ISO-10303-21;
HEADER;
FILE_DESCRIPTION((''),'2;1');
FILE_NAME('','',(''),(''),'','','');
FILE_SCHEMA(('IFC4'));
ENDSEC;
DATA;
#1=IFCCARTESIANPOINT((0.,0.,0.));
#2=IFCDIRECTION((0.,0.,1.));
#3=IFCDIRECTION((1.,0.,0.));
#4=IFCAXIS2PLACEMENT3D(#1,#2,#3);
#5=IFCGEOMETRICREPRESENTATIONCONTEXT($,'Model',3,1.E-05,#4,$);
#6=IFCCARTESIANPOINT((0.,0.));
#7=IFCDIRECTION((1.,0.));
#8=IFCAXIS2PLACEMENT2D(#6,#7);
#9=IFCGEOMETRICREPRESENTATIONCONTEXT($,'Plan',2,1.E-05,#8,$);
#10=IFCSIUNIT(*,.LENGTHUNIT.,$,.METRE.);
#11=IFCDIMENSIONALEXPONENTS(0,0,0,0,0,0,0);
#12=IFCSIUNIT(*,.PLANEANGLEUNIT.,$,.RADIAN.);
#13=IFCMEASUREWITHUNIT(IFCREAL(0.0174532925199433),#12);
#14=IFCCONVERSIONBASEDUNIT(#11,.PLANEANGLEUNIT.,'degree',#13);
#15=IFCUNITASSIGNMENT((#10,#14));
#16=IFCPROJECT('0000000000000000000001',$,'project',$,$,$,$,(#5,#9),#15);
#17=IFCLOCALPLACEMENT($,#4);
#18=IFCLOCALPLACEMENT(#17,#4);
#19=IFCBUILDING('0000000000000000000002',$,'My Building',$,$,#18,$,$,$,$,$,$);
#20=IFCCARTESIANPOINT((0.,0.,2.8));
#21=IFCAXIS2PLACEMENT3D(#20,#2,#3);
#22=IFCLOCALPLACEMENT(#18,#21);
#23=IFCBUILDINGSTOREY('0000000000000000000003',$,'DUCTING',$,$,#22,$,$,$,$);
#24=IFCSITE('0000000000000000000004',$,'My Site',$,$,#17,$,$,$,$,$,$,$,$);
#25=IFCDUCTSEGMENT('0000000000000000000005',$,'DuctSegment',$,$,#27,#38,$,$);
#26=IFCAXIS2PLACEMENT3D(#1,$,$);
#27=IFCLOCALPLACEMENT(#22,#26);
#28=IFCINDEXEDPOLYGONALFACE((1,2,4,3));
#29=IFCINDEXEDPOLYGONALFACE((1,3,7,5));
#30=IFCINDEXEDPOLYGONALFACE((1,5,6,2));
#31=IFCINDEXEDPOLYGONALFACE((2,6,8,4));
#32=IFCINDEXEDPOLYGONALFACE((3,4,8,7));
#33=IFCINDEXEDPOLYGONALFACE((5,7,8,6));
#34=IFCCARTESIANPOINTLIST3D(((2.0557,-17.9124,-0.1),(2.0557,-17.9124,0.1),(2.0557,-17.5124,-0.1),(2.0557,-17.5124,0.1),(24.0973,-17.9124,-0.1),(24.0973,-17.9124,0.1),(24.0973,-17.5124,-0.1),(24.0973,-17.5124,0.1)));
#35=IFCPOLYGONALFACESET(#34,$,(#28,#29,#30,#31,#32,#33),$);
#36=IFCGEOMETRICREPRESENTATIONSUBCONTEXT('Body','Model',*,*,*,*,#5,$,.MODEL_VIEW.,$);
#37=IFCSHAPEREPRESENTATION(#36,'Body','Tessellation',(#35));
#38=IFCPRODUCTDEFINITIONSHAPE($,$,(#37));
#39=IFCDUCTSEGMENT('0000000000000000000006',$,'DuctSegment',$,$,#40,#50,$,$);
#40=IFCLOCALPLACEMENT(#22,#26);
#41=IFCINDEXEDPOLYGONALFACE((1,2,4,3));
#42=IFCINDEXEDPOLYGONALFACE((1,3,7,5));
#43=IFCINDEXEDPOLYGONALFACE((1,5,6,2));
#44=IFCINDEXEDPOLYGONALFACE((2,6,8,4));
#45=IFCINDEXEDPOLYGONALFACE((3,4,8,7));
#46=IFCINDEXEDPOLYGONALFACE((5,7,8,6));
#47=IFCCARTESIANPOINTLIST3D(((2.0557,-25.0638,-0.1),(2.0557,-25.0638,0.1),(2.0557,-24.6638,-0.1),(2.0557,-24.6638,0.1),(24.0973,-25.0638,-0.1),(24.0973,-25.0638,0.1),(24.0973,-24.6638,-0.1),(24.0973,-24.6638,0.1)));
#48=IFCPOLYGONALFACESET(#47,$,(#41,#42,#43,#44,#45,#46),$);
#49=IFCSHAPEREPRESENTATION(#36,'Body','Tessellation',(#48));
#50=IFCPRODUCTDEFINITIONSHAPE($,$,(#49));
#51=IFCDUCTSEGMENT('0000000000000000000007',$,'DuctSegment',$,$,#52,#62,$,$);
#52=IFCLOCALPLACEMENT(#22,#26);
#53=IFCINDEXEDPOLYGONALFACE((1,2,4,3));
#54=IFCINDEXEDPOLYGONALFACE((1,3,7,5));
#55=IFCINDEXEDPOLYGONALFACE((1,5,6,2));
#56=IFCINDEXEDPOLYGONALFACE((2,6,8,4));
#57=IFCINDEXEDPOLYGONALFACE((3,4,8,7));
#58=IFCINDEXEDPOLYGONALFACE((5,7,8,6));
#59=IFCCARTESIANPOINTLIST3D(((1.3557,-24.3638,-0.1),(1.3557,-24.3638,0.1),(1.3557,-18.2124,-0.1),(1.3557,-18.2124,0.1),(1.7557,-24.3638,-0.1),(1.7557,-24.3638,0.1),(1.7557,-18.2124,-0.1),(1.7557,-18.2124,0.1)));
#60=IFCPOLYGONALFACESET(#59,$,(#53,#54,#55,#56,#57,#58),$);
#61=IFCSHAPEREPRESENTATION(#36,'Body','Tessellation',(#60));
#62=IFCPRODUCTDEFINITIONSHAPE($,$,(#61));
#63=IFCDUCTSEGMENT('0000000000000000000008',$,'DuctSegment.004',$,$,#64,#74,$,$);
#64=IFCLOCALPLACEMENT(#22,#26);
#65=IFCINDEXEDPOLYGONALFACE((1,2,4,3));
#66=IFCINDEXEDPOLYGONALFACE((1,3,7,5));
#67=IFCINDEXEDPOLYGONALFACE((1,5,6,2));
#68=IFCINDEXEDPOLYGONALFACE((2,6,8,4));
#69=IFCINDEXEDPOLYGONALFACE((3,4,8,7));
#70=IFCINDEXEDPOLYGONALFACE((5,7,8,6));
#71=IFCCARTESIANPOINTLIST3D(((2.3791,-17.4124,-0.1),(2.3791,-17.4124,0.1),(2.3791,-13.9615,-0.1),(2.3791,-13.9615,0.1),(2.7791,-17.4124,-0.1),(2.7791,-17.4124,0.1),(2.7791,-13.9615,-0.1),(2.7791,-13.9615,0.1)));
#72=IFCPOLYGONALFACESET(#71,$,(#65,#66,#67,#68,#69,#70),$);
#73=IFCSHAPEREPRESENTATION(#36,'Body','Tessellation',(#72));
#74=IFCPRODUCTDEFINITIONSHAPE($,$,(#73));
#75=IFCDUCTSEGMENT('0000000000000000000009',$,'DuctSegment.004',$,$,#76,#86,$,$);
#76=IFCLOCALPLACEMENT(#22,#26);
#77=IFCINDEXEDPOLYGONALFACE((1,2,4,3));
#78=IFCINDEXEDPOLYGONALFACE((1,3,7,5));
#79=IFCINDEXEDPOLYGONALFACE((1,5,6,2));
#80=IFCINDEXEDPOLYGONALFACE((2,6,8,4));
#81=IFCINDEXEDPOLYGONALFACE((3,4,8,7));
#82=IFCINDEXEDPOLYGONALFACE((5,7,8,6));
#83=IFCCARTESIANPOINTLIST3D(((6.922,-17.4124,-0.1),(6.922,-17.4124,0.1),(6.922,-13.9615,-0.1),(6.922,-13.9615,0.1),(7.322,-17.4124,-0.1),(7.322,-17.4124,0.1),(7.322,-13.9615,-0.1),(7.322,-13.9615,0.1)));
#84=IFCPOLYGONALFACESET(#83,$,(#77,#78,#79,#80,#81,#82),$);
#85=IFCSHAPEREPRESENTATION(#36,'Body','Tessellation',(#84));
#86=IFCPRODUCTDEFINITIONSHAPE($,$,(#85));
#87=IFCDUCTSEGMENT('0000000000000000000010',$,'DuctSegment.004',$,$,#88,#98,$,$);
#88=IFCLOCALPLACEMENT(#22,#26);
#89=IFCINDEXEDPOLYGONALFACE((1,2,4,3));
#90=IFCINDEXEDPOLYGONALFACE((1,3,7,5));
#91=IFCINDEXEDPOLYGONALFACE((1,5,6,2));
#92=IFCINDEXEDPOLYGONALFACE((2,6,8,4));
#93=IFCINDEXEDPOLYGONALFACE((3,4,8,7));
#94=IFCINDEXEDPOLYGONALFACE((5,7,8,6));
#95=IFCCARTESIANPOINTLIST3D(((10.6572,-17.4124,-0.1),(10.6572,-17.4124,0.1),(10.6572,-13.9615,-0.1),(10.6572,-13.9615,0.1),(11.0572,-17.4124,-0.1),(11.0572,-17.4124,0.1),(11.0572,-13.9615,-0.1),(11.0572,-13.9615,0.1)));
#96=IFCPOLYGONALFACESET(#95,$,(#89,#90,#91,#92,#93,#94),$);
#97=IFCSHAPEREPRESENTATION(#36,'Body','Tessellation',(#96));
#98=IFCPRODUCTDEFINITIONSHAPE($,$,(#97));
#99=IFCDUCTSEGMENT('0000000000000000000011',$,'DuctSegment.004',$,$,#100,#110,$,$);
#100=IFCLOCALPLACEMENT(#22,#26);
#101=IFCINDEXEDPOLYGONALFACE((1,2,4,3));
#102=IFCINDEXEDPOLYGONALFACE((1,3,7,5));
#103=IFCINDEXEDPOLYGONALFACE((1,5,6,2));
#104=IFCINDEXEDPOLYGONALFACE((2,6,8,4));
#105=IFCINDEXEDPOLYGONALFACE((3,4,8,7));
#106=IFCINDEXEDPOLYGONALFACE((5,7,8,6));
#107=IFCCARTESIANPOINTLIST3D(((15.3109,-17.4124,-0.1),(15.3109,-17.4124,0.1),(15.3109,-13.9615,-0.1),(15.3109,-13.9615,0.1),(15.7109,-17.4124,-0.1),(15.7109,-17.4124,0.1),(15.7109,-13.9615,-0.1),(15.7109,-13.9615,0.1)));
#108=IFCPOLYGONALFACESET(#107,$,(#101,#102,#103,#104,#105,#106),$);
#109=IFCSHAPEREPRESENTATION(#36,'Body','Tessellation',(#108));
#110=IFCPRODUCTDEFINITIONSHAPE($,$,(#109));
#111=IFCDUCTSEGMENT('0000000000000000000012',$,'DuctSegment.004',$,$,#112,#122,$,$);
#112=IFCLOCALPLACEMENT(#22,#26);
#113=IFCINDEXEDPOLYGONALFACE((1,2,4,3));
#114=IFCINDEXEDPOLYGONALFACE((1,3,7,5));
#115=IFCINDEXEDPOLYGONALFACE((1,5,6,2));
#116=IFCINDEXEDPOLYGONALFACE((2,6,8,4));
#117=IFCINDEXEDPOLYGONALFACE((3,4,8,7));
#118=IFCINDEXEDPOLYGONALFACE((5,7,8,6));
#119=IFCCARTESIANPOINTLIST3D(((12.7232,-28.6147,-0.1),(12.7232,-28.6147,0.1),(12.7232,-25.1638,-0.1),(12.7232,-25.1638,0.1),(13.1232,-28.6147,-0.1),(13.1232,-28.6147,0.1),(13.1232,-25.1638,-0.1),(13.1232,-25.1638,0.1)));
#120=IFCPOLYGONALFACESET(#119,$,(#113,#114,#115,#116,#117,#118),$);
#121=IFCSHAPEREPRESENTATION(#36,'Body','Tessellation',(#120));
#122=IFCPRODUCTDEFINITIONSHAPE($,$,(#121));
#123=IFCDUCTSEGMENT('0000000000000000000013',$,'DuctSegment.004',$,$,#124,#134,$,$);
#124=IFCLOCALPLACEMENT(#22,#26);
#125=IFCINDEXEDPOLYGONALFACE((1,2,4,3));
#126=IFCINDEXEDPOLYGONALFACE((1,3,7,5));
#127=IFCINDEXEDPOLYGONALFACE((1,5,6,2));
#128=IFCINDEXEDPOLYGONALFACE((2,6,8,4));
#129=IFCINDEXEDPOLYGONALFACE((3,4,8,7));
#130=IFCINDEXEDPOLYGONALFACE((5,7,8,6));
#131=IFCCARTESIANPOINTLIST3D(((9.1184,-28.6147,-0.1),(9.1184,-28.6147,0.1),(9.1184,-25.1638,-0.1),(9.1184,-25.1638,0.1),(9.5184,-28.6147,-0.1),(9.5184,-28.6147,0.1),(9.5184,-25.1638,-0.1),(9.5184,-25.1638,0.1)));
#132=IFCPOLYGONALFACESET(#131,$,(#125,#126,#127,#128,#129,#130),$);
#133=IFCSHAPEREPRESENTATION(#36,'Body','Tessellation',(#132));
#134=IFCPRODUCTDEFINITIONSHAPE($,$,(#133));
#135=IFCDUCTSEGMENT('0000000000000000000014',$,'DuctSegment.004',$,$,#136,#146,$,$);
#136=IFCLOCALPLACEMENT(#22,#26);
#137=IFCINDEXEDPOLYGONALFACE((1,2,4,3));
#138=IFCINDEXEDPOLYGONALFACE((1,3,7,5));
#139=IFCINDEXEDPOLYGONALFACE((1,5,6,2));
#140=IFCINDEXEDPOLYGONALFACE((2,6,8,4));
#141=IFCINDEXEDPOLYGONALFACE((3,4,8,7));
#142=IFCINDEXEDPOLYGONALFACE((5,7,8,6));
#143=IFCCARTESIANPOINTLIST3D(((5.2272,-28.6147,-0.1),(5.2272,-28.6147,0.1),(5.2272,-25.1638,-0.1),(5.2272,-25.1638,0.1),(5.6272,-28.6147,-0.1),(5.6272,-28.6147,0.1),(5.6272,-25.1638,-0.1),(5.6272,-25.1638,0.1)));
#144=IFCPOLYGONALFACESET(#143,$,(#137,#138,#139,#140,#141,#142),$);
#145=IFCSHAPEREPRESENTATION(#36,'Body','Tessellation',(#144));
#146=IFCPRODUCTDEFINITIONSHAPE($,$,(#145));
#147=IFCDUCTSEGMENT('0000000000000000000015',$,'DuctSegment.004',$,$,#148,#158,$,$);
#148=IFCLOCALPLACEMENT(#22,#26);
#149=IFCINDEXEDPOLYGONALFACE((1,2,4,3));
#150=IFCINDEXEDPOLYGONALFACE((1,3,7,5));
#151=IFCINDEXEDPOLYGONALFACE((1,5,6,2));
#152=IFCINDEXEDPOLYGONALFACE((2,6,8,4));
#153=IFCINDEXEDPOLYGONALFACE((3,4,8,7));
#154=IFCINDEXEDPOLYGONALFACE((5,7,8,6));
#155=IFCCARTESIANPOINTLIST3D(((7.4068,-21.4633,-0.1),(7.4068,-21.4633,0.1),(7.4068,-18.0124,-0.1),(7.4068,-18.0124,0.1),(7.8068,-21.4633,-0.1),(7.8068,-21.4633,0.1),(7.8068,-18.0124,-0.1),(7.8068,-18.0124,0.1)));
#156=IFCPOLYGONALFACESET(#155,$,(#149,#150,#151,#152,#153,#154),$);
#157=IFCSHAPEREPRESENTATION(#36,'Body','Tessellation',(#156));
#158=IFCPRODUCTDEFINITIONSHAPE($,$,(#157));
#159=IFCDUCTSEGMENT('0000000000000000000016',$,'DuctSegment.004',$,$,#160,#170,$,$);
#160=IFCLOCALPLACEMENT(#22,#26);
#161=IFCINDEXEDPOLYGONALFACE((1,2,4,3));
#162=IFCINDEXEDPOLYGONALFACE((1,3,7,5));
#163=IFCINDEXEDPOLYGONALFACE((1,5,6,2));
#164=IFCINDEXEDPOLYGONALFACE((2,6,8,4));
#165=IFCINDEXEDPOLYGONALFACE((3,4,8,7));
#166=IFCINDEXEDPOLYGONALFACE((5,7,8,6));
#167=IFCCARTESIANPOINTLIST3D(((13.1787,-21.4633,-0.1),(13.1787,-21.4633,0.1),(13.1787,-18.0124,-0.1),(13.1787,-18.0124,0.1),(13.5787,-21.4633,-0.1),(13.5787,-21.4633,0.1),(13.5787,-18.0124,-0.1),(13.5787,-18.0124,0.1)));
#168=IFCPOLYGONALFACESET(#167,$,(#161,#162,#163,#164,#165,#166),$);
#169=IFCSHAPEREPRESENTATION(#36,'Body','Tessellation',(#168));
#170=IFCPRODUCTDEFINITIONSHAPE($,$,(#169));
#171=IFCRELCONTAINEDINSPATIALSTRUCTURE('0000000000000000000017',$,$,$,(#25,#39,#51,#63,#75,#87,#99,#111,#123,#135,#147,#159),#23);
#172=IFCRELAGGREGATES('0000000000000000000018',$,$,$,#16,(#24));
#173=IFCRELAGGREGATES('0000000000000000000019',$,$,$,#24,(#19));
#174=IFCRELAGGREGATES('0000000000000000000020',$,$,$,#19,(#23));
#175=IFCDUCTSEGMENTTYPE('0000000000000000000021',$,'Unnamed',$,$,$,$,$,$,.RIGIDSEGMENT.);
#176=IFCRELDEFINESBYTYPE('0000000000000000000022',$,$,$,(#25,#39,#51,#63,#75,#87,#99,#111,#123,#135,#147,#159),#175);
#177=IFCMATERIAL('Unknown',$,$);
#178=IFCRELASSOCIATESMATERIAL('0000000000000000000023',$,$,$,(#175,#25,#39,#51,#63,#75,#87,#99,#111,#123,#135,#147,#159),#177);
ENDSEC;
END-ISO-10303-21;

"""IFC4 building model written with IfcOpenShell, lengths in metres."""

from ifc_helpers import new_model, entity, si_unit, converted_unit, frame, origin_with_axes, origin_2d_with_axis, place, context, subcontext, project, spatial, rectangle, extrude, material, material_profile, profile_set, profile_usage, type_object, element, save


model = new_model("IFC4")

# Units and contexts
model_context = context("Model", 3, precision=1e-05, world=origin_with_axes())
plan_context = context("Plan", 2, precision=1e-05, world=origin_2d_with_axis())
body_context = subcontext(model_context, "Body", "Model", "MODEL_VIEW")
ifc_project = project(units=[si_unit("LENGTHUNIT", "METRE"), converted_unit("PLANEANGLEUNIT", "degree", entity("IfcReal", 0.0174532925199433), si_unit("PLANEANGLEUNIT", "RADIAN"), dimensions=[0, 0, 0, 0, 0, 0, 0])], contexts=[model_context, plan_context])

# Site, building, storey
site_placement = place(None, origin_with_axes())
site = spatial("IfcSite", under=ifc_project, at=site_placement, Name="My Site")
building_placement = place(site_placement, origin_with_axes())
building = spatial("IfcBuilding", under=site, at=building_placement, Name="My Building")
storey_placement = place(building_placement, frame((0.0, 0.0, 2.8), z_axis=(0.0, 0.0, 1.0), x_axis=(1.0, 0.0, 0.0)))
storey = spatial("IfcBuildingStorey", under=building, at=storey_placement, Name="DUCTING")

# Duct segments
ifc_material = material(Name="Unknown")
ifc_material_profile_1 = material_profile(ifc_material, rectangle(XDim=0.4, YDim=0.2))
ifc_profile_set_1 = profile_set([ifc_material_profile_1])
ifc_profile_usage_1 = profile_usage(ifc_profile_set_1, cardinal=5)
duct_segment_type = type_object("IfcDuctSegmentType", Name="Unnamed", PredefinedType="RIGIDSEGMENT", material=ifc_profile_set_1)
duct_segment_1_placement = place(storey_placement, frame((2.0557, -17.7124, 0.0), z_axis=(1.0, 0.0, 0.0), x_axis=(0.0, 1.0, 0.0)))
element("IfcDuctSegment", 1, at=duct_segment_1_placement, inside=storey, type_object=duct_segment_type, material=ifc_profile_usage_1, Name="DuctSegment", context=body_context, shape_type="SweptSolid", body=[
    extrude(rectangle(XDim=0.4, YDim=0.2), origin_with_axes(), (0.0, 0.0, 1.0), 22.0417),
])
ifc_profile_usage_2 = profile_usage(ifc_profile_set_1, cardinal=5)
duct_segment_2_placement = place(storey_placement, frame((2.0557, -24.8638, 0.0), z_axis=(1.0, 0.0, 0.0), x_axis=(0.0, 1.0, 0.0)))
element("IfcDuctSegment", 2, at=duct_segment_2_placement, inside=storey, type_object=duct_segment_type, material=ifc_profile_usage_2, Name="DuctSegment", context=body_context, shape_type="SweptSolid", body=[
    extrude(rectangle(XDim=0.4, YDim=0.2), origin_with_axes(), (0.0, 0.0, 1.0), 22.0417),
])
ifc_profile_usage_3 = profile_usage(ifc_profile_set_1, cardinal=5)
duct_segment_3_placement = place(storey_placement, frame((1.5557, -18.2124, 0.0), z_axis=(0.0, -1.0, 0.0), x_axis=(1.0, 0.0, 0.0)))
element("IfcDuctSegment", 3, at=duct_segment_3_placement, inside=storey, type_object=duct_segment_type, material=ifc_profile_usage_3, Name="DuctSegment", context=body_context, shape_type="SweptSolid", body=[
    extrude(rectangle(XDim=0.4, YDim=0.2), origin_with_axes(), (0.0, 0.0, 1.0), 6.1514),
])
ifc_profile_usage_4 = profile_usage(ifc_profile_set_1, cardinal=5)
duct_segment_4_placement = place(storey_placement, frame((2.5791, -17.4124, 0.0), z_axis=(0.0, 1.0, 0.0), x_axis=(-1.0, 0.0, 0.0)))
element("IfcDuctSegment", 4, at=duct_segment_4_placement, inside=storey, type_object=duct_segment_type, material=ifc_profile_usage_4, Name="DuctSegment.004", context=body_context, shape_type="SweptSolid", body=[
    extrude(rectangle(XDim=0.4, YDim=0.2), origin_with_axes(), (0.0, 0.0, 1.0), 3.4509),
])
ifc_profile_usage_5 = profile_usage(ifc_profile_set_1, cardinal=5)
duct_segment_5_placement = place(storey_placement, frame((7.122, -17.4124, 0.0), z_axis=(0.0, 1.0, 0.0), x_axis=(-1.0, 0.0, 0.0)))
element("IfcDuctSegment", 5, at=duct_segment_5_placement, inside=storey, type_object=duct_segment_type, material=ifc_profile_usage_5, Name="DuctSegment.004", context=body_context, shape_type="SweptSolid", body=[
    extrude(rectangle(XDim=0.4, YDim=0.2), origin_with_axes(), (0.0, 0.0, 1.0), 3.4509),
])
ifc_profile_usage_6 = profile_usage(ifc_profile_set_1, cardinal=5)
duct_segment_6_placement = place(storey_placement, frame((10.8572, -17.4124, 0.0), z_axis=(0.0, 1.0, 0.0), x_axis=(-1.0, 0.0, 0.0)))
element("IfcDuctSegment", 6, at=duct_segment_6_placement, inside=storey, type_object=duct_segment_type, material=ifc_profile_usage_6, Name="DuctSegment.004", context=body_context, shape_type="SweptSolid", body=[
    extrude(rectangle(XDim=0.4, YDim=0.2), origin_with_axes(), (0.0, 0.0, 1.0), 3.4509),
])
ifc_profile_usage_7 = profile_usage(ifc_profile_set_1, cardinal=5)
duct_segment_7_placement = place(storey_placement, frame((15.5109, -17.4124, 0.0), z_axis=(0.0, 1.0, 0.0), x_axis=(-1.0, 0.0, 0.0)))
element("IfcDuctSegment", 7, at=duct_segment_7_placement, inside=storey, type_object=duct_segment_type, material=ifc_profile_usage_7, Name="DuctSegment.004", context=body_context, shape_type="SweptSolid", body=[
    extrude(rectangle(XDim=0.4, YDim=0.2), origin_with_axes(), (0.0, 0.0, 1.0), 3.4509),
])
ifc_profile_usage_8 = profile_usage(ifc_profile_set_1, cardinal=5)
duct_segment_8_placement = place(storey_placement, frame((12.9232, -25.1638, 0.0), z_axis=(0.0, -1.0, 0.0), x_axis=(1.0, 0.0, 0.0)))
element("IfcDuctSegment", 8, at=duct_segment_8_placement, inside=storey, type_object=duct_segment_type, material=ifc_profile_usage_8, Name="DuctSegment.004", context=body_context, shape_type="SweptSolid", body=[
    extrude(rectangle(XDim=0.4, YDim=0.2), origin_with_axes(), (0.0, 0.0, 1.0), 3.4509),
])
ifc_profile_usage_9 = profile_usage(ifc_profile_set_1, cardinal=5)
duct_segment_9_placement = place(storey_placement, frame((9.3184, -25.1638, 0.0), z_axis=(0.0, -1.0, 0.0), x_axis=(1.0, 0.0, 0.0)))
element("IfcDuctSegment", 9, at=duct_segment_9_placement, inside=storey, type_object=duct_segment_type, material=ifc_profile_usage_9, Name="DuctSegment.004", context=body_context, shape_type="SweptSolid", body=[
    extrude(rectangle(XDim=0.4, YDim=0.2), origin_with_axes(), (0.0, 0.0, 1.0), 3.4509),
])
ifc_profile_usage_10 = profile_usage(ifc_profile_set_1, cardinal=5)
duct_segment_10_placement = place(storey_placement, frame((5.4272, -25.1638, 0.0), z_axis=(0.0, -1.0, 0.0), x_axis=(1.0, 0.0, 0.0)))
element("IfcDuctSegment", 10, at=duct_segment_10_placement, inside=storey, type_object=duct_segment_type, material=ifc_profile_usage_10, Name="DuctSegment.004", context=body_context, shape_type="SweptSolid", body=[
    extrude(rectangle(XDim=0.4, YDim=0.2), origin_with_axes(), (0.0, 0.0, 1.0), 3.4509),
])
ifc_profile_usage_11 = profile_usage(ifc_profile_set_1, cardinal=5)
duct_segment_11_placement = place(storey_placement, frame((7.6068, -18.0124, 0.0), z_axis=(0.0, -1.0, 0.0), x_axis=(1.0, 0.0, 0.0)))
element("IfcDuctSegment", 11, at=duct_segment_11_placement, inside=storey, type_object=duct_segment_type, material=ifc_profile_usage_11, Name="DuctSegment.004", context=body_context, shape_type="SweptSolid", body=[
    extrude(rectangle(XDim=0.4, YDim=0.2), origin_with_axes(), (0.0, 0.0, 1.0), 3.4509),
])
ifc_profile_usage_12 = profile_usage(ifc_profile_set_1, cardinal=5)
duct_segment_12_placement = place(storey_placement, frame((13.3787, -18.0124, 0.0), z_axis=(0.0, -1.0, 0.0), x_axis=(1.0, 0.0, 0.0)))
element("IfcDuctSegment", 12, at=duct_segment_12_placement, inside=storey, type_object=duct_segment_type, material=ifc_profile_usage_12, Name="DuctSegment.004", context=body_context, shape_type="SweptSolid", body=[
    extrude(rectangle(XDim=0.4, YDim=0.2), origin_with_axes(), (0.0, 0.0, 1.0), 3.4509),
])

save(model, "model.ifc")
